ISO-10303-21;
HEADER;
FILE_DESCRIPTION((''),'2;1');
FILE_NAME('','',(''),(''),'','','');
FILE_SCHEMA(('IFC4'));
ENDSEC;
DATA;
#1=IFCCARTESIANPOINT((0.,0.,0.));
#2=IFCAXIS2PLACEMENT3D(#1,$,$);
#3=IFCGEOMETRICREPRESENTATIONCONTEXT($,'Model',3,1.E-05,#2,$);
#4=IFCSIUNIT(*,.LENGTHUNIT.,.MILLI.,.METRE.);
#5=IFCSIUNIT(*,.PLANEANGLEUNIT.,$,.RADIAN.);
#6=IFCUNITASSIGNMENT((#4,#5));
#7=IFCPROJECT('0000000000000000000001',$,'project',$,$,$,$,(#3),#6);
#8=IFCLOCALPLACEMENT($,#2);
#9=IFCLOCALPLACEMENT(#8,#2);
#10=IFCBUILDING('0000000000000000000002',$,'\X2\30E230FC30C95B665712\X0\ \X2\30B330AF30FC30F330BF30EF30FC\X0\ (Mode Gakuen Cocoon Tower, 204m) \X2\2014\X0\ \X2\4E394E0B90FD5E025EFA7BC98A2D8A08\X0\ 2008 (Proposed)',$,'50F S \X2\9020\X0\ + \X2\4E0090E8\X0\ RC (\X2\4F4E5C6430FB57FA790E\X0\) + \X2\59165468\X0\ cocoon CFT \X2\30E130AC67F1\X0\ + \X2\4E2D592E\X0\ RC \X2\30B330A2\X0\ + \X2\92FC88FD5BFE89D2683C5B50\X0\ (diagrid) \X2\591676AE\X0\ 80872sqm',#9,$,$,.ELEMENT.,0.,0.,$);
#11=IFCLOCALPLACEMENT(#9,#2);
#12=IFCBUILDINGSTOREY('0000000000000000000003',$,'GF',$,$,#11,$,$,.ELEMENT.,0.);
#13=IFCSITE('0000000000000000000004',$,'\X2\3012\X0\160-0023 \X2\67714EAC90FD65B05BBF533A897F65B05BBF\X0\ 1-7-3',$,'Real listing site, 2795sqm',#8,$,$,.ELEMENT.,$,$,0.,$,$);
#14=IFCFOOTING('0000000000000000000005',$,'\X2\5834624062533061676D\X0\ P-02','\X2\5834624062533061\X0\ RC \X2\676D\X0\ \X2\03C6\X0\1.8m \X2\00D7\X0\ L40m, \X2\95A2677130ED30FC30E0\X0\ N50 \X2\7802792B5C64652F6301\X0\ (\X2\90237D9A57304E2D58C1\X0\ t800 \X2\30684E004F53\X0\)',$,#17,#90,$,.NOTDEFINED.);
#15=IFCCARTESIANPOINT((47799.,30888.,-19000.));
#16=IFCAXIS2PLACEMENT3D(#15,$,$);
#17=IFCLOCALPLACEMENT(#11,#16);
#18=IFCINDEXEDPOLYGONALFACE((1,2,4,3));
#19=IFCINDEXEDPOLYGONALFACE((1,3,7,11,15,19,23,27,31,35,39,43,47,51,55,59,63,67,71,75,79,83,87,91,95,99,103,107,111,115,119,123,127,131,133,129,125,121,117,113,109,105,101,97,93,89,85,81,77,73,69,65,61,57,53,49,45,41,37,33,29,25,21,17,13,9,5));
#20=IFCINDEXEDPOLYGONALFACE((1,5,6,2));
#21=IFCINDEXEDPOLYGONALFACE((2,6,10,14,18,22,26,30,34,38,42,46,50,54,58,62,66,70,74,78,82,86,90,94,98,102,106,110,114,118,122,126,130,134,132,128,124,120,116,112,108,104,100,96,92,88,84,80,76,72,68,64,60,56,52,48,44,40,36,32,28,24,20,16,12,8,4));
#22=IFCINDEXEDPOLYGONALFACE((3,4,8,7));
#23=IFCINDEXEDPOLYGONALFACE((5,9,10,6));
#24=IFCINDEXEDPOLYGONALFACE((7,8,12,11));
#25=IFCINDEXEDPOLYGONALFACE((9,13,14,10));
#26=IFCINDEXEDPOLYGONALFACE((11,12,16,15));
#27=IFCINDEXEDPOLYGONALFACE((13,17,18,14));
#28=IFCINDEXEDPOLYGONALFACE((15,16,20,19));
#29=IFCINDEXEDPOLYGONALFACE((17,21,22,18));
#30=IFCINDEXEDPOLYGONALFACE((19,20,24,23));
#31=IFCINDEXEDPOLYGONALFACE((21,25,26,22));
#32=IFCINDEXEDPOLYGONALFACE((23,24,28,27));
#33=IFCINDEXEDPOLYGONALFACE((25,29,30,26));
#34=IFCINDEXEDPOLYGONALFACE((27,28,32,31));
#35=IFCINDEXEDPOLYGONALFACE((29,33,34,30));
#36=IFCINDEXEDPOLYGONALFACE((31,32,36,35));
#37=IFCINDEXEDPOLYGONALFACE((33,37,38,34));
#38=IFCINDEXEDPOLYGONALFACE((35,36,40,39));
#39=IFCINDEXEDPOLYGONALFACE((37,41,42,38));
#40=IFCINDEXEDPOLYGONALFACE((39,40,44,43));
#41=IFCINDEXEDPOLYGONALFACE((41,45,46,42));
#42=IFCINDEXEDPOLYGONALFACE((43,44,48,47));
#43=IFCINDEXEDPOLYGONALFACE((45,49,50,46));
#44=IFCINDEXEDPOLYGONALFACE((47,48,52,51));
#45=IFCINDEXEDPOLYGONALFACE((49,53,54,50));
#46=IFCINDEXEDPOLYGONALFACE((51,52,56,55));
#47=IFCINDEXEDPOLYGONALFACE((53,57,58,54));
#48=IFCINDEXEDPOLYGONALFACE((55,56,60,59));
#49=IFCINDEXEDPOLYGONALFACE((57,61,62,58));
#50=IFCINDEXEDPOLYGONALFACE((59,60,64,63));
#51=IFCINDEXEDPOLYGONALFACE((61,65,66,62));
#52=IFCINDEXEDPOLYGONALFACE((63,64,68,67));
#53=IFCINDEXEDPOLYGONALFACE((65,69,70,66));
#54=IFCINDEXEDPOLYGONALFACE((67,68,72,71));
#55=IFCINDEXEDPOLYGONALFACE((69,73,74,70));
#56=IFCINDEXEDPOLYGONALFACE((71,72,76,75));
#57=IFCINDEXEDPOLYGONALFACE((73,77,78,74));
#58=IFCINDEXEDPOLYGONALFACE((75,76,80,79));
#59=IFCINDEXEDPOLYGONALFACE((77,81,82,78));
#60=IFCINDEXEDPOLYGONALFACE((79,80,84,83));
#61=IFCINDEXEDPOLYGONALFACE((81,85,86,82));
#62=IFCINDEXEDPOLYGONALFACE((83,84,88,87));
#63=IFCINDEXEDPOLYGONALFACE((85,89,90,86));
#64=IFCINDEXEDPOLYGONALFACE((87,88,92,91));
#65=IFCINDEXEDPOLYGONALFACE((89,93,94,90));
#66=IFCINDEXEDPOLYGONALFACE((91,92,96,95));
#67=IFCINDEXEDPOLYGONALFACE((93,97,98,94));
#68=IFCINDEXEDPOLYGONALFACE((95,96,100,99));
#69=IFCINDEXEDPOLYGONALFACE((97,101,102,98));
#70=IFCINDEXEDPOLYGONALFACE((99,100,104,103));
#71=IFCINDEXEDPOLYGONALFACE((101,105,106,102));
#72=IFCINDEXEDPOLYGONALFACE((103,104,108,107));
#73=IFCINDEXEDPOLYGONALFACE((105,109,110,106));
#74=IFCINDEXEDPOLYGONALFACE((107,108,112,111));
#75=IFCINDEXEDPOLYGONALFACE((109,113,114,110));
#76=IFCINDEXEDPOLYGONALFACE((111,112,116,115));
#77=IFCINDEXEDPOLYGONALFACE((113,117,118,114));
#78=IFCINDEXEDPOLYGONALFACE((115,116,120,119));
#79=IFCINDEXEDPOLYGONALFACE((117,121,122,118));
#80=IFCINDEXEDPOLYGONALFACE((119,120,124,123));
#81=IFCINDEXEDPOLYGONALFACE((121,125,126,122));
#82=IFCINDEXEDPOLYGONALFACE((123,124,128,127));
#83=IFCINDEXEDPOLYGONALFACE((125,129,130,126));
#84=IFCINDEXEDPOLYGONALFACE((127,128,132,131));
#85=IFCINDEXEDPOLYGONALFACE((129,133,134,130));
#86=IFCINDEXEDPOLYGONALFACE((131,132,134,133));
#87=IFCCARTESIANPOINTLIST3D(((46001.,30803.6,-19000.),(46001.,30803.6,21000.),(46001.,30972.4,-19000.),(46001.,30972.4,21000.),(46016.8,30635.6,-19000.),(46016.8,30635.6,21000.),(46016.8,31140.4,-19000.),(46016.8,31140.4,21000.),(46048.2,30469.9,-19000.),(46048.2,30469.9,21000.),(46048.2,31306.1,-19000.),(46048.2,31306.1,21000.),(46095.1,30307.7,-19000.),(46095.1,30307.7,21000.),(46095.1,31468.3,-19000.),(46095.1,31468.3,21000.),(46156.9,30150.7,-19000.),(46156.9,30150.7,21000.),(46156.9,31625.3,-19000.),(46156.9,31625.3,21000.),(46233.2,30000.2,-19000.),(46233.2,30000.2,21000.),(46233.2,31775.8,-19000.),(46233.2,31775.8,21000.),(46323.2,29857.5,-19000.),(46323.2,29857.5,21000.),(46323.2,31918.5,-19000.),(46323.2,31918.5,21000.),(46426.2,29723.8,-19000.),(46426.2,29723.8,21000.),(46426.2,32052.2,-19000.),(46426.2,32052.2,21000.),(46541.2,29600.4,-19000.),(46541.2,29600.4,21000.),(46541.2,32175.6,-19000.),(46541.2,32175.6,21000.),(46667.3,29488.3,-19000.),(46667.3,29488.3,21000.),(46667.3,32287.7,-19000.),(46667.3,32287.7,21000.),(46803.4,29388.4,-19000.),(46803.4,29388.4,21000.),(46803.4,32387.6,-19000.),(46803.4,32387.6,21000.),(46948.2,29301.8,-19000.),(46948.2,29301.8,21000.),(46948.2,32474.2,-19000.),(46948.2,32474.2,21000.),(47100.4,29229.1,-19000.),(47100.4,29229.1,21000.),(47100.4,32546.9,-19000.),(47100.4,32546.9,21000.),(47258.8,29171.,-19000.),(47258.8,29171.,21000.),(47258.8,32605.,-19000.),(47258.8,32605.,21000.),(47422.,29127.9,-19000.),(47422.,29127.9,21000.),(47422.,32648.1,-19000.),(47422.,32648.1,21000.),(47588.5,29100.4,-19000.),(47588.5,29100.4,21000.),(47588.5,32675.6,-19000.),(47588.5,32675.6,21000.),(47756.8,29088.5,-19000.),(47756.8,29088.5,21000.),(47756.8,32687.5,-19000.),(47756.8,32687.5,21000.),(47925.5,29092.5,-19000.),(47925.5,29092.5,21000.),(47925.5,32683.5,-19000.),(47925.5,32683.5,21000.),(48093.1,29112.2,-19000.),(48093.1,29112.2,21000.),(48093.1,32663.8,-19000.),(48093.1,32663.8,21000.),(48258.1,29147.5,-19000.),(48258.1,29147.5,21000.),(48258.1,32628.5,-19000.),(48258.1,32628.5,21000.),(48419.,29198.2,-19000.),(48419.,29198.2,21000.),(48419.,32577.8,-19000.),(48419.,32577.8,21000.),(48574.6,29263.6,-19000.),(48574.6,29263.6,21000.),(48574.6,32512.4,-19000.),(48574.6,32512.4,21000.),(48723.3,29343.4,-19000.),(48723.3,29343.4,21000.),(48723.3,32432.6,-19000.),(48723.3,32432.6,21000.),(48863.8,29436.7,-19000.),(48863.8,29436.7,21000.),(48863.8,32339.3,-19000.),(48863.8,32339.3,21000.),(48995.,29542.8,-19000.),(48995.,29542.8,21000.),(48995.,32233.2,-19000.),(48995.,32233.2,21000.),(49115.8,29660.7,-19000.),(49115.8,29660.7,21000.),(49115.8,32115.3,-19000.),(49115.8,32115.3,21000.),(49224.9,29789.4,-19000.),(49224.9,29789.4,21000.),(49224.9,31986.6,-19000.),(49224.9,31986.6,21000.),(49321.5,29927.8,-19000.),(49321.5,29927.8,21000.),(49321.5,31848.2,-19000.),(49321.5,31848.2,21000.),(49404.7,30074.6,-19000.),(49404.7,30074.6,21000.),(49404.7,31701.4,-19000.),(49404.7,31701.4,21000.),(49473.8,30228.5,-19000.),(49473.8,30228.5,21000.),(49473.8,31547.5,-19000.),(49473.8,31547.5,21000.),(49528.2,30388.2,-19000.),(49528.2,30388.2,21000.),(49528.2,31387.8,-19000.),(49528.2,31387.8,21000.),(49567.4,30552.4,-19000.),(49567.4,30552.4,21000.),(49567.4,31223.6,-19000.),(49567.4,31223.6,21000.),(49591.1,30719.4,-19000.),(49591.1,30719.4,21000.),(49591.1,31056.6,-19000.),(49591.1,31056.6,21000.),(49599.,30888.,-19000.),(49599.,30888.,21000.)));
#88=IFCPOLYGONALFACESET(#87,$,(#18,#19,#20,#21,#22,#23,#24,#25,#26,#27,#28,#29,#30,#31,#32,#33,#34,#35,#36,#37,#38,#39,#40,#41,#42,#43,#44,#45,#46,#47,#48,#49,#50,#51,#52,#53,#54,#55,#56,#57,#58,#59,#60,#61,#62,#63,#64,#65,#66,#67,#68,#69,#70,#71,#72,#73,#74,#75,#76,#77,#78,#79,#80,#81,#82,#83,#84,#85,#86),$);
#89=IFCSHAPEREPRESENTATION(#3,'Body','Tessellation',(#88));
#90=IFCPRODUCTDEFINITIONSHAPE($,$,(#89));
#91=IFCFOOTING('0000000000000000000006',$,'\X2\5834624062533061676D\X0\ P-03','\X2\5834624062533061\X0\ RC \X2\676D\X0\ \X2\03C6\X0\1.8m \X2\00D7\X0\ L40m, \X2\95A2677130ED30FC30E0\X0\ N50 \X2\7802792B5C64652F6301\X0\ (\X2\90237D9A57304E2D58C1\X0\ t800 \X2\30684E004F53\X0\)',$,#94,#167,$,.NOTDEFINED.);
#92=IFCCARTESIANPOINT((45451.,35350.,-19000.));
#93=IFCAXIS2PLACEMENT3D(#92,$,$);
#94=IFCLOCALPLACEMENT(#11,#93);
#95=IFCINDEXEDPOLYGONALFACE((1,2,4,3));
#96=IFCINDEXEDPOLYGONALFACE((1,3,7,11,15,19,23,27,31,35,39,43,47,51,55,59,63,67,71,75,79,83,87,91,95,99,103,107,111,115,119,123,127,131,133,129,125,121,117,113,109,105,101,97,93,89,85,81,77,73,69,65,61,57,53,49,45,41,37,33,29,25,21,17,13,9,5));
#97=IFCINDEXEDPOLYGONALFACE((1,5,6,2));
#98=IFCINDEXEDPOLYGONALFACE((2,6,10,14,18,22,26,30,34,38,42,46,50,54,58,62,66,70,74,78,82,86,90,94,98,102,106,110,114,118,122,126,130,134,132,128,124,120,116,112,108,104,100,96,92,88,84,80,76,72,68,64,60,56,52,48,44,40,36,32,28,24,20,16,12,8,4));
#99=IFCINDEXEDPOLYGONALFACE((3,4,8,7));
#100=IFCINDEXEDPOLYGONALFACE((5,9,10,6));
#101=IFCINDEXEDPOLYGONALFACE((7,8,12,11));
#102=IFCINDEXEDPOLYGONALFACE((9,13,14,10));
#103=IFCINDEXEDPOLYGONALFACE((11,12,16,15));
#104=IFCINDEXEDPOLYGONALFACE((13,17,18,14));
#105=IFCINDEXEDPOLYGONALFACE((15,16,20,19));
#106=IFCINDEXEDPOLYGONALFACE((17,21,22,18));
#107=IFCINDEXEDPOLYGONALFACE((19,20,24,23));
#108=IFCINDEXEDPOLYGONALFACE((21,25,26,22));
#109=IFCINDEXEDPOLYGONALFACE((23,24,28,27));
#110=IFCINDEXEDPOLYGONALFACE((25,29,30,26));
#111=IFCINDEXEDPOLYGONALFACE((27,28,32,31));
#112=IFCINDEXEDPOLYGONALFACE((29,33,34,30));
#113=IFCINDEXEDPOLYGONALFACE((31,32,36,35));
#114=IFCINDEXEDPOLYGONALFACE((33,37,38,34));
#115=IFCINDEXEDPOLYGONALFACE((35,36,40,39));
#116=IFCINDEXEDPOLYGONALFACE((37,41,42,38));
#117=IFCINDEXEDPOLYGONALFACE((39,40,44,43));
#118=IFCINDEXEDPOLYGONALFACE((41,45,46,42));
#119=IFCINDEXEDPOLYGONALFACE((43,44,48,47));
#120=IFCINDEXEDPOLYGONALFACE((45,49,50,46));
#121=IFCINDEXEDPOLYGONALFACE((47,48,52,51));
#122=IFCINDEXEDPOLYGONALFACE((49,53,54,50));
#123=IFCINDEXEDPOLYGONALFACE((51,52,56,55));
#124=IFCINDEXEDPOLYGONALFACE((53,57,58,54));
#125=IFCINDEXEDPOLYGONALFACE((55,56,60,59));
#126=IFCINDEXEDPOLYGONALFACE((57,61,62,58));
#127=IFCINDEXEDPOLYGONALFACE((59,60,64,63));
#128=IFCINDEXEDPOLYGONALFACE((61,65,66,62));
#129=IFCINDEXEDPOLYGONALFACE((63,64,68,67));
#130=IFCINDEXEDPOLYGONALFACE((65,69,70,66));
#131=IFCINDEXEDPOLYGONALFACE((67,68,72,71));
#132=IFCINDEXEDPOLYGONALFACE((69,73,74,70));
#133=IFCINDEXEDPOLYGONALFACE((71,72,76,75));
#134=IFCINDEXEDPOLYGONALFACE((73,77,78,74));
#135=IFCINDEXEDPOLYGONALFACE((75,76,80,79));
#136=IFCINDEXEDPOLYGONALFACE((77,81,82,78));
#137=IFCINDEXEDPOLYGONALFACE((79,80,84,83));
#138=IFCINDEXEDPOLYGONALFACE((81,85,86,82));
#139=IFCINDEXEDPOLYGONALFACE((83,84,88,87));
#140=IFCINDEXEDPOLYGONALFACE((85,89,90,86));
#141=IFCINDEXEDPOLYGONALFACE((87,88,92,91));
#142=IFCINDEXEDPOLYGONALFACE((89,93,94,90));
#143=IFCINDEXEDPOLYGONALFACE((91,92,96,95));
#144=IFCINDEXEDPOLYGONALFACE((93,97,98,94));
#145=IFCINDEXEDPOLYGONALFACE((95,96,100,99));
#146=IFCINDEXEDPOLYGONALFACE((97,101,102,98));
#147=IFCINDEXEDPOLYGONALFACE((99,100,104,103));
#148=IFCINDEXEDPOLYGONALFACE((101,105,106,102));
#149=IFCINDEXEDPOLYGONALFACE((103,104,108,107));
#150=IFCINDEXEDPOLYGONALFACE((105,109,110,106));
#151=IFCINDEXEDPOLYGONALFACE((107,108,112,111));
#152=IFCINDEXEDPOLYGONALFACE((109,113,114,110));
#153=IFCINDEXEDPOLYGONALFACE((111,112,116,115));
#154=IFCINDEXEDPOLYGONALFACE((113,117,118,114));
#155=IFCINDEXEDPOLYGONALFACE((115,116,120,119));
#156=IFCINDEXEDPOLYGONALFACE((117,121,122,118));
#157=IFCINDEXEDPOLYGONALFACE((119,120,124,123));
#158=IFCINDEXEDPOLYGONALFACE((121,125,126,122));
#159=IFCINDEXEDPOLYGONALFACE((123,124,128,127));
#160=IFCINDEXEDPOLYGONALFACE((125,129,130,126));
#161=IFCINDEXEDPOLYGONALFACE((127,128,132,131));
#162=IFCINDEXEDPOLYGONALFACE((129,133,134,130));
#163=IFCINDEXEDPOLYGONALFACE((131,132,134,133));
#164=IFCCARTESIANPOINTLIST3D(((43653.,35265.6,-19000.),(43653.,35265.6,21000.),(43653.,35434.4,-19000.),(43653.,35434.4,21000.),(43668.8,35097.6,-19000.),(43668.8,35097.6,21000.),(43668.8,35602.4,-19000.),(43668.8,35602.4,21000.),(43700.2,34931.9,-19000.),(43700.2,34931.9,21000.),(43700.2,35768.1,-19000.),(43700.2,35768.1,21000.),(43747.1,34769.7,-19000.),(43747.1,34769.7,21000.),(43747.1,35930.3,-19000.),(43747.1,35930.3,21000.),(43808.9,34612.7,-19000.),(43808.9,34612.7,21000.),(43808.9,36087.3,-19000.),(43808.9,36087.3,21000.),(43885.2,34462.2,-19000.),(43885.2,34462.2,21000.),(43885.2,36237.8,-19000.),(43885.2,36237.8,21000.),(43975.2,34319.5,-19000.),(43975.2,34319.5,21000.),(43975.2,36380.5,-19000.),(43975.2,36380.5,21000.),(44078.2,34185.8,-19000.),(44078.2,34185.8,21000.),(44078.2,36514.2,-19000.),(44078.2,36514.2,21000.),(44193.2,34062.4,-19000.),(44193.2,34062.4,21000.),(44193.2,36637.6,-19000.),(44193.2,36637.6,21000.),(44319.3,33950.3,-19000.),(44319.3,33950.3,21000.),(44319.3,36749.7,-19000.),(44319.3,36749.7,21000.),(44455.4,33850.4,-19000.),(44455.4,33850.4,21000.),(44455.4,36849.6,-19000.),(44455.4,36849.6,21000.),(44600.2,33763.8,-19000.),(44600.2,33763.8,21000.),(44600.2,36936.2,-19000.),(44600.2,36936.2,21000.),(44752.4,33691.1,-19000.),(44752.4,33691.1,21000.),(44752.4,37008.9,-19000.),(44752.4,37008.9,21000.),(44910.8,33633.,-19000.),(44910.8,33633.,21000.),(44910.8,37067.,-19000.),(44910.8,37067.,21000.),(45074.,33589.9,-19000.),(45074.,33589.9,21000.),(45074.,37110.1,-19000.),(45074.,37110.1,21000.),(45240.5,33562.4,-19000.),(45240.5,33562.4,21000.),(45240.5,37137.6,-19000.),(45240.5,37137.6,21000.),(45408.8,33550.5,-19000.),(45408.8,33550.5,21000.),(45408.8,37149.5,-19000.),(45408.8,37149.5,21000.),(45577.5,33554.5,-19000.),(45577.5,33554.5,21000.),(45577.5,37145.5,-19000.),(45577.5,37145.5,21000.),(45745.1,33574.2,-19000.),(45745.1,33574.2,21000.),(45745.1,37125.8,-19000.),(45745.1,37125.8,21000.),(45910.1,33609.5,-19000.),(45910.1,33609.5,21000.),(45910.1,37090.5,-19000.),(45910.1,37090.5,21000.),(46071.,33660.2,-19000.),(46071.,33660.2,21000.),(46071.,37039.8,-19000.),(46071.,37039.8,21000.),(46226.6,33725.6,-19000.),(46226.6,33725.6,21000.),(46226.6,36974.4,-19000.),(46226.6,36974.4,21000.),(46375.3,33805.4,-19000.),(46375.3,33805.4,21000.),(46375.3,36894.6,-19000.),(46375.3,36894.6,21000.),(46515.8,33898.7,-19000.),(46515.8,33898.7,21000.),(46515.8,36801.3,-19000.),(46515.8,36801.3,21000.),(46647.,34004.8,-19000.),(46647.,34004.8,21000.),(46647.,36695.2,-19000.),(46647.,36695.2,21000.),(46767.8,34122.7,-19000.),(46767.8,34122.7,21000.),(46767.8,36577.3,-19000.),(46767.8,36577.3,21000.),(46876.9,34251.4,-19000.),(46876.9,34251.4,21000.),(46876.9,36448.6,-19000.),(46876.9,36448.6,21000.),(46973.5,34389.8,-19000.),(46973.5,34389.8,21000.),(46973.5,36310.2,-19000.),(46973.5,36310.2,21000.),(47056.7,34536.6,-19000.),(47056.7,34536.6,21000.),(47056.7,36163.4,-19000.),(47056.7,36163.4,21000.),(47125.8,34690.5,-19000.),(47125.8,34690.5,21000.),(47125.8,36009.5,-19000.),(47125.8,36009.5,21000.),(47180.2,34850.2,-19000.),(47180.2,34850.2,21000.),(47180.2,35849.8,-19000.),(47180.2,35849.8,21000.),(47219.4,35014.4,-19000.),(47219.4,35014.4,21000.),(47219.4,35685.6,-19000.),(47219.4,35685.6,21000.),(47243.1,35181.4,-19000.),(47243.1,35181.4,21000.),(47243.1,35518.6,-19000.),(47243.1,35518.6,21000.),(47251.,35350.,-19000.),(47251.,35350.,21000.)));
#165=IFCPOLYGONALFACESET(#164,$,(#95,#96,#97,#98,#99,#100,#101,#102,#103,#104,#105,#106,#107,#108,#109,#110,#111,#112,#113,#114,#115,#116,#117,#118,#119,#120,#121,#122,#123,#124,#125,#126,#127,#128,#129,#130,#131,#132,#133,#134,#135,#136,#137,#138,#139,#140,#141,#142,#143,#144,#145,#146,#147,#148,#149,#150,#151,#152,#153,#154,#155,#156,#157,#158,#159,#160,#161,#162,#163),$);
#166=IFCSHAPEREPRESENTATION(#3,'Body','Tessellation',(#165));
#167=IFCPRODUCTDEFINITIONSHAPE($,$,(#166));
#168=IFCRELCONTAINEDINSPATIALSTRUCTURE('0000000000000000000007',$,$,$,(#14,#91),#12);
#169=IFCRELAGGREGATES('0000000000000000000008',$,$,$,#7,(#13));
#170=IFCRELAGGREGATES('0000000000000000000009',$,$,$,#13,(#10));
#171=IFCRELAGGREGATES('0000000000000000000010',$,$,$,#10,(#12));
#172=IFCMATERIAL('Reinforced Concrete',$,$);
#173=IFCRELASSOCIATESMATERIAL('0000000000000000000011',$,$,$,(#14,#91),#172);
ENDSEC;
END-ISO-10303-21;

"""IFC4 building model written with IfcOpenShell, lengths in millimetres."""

from ifc_helpers import new_model, si_unit, frame, origin, origin_2d, place, context, project, spatial, circle, extrude, material, element, save


model = new_model("IFC4")

# Units and contexts
model_context = context("Model", 3, precision=1e-05, world=origin())
ifc_project = project(units=[si_unit("LENGTHUNIT", "METRE", prefix="MILLI"), si_unit("PLANEANGLEUNIT", "RADIAN")], contexts=[model_context])

# Site, building, storey
site_placement = place(None, origin())
site = spatial("IfcSite", under=ifc_project, at=site_placement, Name="〒160-0023 東京都新宿区西新宿 1-7-3", ObjectType="Real listing site, 2795sqm", CompositionType="ELEMENT", RefElevation=0.0)
building_placement = place(site_placement, origin())
building = spatial("IfcBuilding", under=site, at=building_placement, Name="モード学園 コクーンタワー (Mode Gakuen Cocoon Tower, 204m) — 丹下都市建築設計 2008 (Proposed)", ObjectType="50F S 造 + 一部 RC (低層・基礎) + 外周 cocoon CFT メガ柱 + 中央 RC コア + 鋼製対角格子 (diagrid) 外皮 80872sqm", CompositionType="ELEMENT", ElevationOfRefHeight=0.0, ElevationOfTerrain=0.0)
storey_placement = place(building_placement, origin())
storey = spatial("IfcBuildingStorey", under=building, at=storey_placement, Name="GF", CompositionType="ELEMENT", Elevation=0.0)

# Footings
ifc_material_1 = material(Name="Reinforced Concrete")
footing_1_placement = place(storey_placement, frame((47799.0, 30888.0, -19000.0)))
element("IfcFooting", 1, at=footing_1_placement, inside=storey, material=ifc_material_1, Name="場所打ち杭 P-02", Description="場所打ち RC 杭 φ1.8m × L40m, 関東ローム N50 砂礫層支持 (連続地中壁 t800 と一体)", PredefinedType="NOTDEFINED", context=model_context, shape_type="SweptSolid", body=[
    extrude(circle(Radius=1800.0, at=origin_2d()), frame((47799.0, 30888.0, -19000.0)), (0.0, 0.0, 1.0), 40000.0),
])
footing_2_placement = place(storey_placement, frame((45451.0, 35350.0, -19000.0)))
element("IfcFooting", 2, at=footing_2_placement, inside=storey, material=ifc_material_1, Name="場所打ち杭 P-03", Description="場所打ち RC 杭 φ1.8m × L40m, 関東ローム N50 砂礫層支持 (連続地中壁 t800 と一体)", PredefinedType="NOTDEFINED", context=model_context, shape_type="SweptSolid", body=[
    extrude(circle(Radius=1800.0, at=origin_2d()), frame((45451.0, 35350.0, -19000.0)), (0.0, 0.0, 1.0), 40000.0),
])

save(model, "model.ifc")
